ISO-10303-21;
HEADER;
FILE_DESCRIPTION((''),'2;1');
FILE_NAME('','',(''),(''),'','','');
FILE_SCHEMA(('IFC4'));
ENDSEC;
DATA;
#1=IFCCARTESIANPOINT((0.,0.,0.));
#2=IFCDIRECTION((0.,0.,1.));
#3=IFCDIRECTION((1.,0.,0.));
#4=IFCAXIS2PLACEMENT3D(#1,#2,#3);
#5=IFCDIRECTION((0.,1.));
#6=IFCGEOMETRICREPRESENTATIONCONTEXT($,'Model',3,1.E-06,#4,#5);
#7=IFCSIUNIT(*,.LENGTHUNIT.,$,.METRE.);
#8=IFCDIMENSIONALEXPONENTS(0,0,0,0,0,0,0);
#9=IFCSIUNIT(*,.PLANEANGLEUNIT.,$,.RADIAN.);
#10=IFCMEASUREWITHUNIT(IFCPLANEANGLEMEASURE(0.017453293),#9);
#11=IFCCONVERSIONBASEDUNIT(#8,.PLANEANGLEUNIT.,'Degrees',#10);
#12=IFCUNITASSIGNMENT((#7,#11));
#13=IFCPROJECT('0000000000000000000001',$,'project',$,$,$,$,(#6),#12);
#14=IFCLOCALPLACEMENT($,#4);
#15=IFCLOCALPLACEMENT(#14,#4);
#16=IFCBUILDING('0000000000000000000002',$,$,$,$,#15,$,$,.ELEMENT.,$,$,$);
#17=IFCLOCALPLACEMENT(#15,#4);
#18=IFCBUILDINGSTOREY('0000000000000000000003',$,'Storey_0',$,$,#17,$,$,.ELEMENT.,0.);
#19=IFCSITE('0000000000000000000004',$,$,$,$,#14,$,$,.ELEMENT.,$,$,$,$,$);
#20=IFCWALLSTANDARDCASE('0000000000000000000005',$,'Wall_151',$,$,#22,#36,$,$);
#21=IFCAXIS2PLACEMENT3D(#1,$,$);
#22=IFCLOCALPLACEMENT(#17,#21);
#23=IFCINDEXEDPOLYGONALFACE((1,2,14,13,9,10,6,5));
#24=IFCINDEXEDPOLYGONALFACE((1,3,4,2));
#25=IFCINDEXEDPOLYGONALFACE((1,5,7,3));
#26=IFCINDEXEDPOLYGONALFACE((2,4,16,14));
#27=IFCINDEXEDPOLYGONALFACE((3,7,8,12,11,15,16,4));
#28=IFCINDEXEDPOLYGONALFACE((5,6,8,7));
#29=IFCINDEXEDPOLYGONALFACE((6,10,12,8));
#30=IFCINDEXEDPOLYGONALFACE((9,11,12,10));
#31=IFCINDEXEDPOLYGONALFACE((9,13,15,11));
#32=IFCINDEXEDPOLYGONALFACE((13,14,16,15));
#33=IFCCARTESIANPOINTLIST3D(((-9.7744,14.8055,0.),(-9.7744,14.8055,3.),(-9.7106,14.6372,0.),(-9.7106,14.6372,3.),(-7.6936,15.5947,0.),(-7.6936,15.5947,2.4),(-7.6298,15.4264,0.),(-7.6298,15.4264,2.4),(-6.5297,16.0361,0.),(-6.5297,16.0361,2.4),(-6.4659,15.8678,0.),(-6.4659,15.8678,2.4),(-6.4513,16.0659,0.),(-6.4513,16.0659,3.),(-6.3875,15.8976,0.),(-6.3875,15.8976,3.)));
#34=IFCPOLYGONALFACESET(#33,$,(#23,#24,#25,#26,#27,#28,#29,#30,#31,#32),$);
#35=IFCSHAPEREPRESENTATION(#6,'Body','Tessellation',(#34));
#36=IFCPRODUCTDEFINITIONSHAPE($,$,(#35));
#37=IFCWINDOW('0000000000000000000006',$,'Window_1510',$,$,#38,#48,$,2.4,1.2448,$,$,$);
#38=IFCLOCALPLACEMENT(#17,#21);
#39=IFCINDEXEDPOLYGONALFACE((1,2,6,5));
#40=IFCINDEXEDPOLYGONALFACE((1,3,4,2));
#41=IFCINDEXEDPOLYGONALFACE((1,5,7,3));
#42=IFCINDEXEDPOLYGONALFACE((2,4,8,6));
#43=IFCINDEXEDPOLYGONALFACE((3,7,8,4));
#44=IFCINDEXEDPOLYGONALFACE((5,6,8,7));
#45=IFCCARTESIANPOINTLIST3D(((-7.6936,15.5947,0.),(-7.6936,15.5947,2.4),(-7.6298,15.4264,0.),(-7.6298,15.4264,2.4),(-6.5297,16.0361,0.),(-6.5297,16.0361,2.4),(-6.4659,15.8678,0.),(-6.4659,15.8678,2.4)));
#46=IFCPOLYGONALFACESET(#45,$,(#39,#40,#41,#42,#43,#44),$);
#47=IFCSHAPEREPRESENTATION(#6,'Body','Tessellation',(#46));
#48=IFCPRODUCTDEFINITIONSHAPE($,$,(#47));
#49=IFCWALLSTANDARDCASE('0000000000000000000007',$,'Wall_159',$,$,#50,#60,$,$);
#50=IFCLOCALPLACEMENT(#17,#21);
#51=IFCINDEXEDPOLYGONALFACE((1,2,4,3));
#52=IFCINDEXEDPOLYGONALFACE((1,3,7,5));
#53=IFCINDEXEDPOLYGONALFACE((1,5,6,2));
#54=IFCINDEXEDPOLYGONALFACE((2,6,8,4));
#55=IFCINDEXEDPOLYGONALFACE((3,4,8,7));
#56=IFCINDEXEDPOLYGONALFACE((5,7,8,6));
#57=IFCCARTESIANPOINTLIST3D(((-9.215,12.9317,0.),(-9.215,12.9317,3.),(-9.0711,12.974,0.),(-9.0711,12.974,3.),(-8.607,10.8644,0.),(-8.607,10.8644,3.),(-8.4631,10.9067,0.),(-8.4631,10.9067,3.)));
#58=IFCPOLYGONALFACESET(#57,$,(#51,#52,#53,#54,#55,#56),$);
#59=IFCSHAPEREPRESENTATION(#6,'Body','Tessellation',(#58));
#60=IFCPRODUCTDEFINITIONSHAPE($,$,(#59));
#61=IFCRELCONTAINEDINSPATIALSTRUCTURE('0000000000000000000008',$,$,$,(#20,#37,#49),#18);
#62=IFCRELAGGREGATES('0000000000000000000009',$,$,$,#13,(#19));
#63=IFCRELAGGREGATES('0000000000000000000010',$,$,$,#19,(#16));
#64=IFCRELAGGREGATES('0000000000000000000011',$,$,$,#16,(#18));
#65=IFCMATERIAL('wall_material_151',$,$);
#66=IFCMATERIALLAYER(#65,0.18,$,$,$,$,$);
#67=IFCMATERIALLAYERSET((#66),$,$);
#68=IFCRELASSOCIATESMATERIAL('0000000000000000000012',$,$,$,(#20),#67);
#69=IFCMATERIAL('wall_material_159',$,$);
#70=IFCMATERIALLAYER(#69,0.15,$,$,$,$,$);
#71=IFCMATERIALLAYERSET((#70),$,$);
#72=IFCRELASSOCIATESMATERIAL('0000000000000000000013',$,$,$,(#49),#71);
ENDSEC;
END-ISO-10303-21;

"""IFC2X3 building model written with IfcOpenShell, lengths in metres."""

from ifc_helpers import new_model, entity, si_unit, converted_unit, direction, frame, frame_2d, origin_with_axes, place, context, project, spatial, polyline, rectangle, outline, extrude, material, layer, layer_set, layer_usage, element, fill, save


model = new_model("IFC2X3")

# Units and contexts
model_context = context("Model", 3, precision=1e-06, world=origin_with_axes(), true_north=direction((0.0, 1.0)))
ifc_project = project(units=[si_unit("LENGTHUNIT", "METRE"), converted_unit("PLANEANGLEUNIT", "Degrees", entity("IfcPlaneAngleMeasure", 0.017453293), si_unit("PLANEANGLEUNIT", "RADIAN"), dimensions=[0, 0, 0, 0, 0, 0, 0])], contexts=[model_context])

# Site, building, storey
site_placement = place(None, origin_with_axes())
site = spatial("IfcSite", under=ifc_project, at=site_placement, CompositionType="ELEMENT")
building_placement = place(site_placement, origin_with_axes())
building = spatial("IfcBuilding", under=site, at=building_placement, CompositionType="ELEMENT")
storey_placement = place(building_placement, origin_with_axes())
storey = spatial("IfcBuildingStorey", under=building, at=storey_placement, Name="Storey_0", CompositionType="ELEMENT", Elevation=0.0)

# Wall, opening, window
ifc_material_1 = material(Name="wall_material_151")
ifc_layer_1 = layer(ifc_material_1, 0.18)
ifc_layer_set_1 = layer_set([ifc_layer_1])
ifc_layer_usage_1 = layer_usage(ifc_layer_set_1, "AXIS2", "NEGATIVE", 0.0)
wall_1_placement = place(storey_placement, frame((-9.7744, 14.8055, 0.0), z_axis=(0.0, 0.0, 1.0), x_axis=(0.935011, 0.354617, 0.0)))
wall_1 = element("IfcWallStandardCase", 1, at=wall_1_placement, inside=storey, material=ifc_layer_usage_1, Name="Wall_151", context=model_context, shape_type="SweptSolid", body=[
    extrude(outline(polyline([(0.0, 0.0), (3.5541, 0.0), (3.5541, -0.18), (0.0, -0.18), (0.0, 0.0)])), origin_with_axes(), (0.0, 0.0, 1.0), 3.0),
])
opening_1_placement = place(wall_1_placement, frame((2.2254, 0.0, 0.0), z_axis=(0.0, 0.0, 1.0), x_axis=(1.0, 0.0, 0.0)))
opening_1 = element("IfcOpeningElement", 2, at=opening_1_placement, cuts=wall_1, context=model_context, shape_type="SweptSolid", body=[
    extrude(rectangle(XDim=1.2448, YDim=2.4, at=frame_2d((1.2, -0.6224), x_axis=(0.0, 1.0))), frame((0.0, 0.01, 0.0), z_axis=(0.0, -1.0, 0.0), x_axis=(0.0, 0.0, 1.0)), (0.0, 0.0, 1.0), 0.2),
])
window_1_placement = place(storey_placement, origin_with_axes())
window_1 = element("IfcWindow", 3, at=window_1_placement, inside=storey, Name="Window_1510", OverallHeight=2.4, OverallWidth=1.2448, context=model_context, shape_type="SweptSolid", body=[
    extrude(outline(polyline([(-7.6936, 15.5947), (-6.5297, 16.0361), (-6.4659, 15.8678), (-7.6298, 15.4264), (-7.6936, 15.5947)])), origin_with_axes(), (0.0, 0.0, 1.0), 2.4),
])
fill(opening_1, window_1)

# Wall
ifc_material_2 = material(Name="wall_material_159")
ifc_layer_2 = layer(ifc_material_2, 0.15)
ifc_layer_set_2 = layer_set([ifc_layer_2])
ifc_layer_usage_2 = layer_usage(ifc_layer_set_2, "AXIS2", "NEGATIVE", 0.0)
wall_2_placement = place(storey_placement, frame((-9.0711, 12.974, 0.0), z_axis=(0.0, 0.0, 1.0), x_axis=(0.282174, -0.959363, 0.0)))
element("IfcWallStandardCase", 4, at=wall_2_placement, inside=storey, material=ifc_layer_usage_2, Name="Wall_159", context=model_context, shape_type="SweptSolid", body=[
    extrude(outline(polyline([(0.0, 0.0), (2.1549, 0.0), (2.1549, -0.15), (0.0, -0.15), (0.0, 0.0)])), origin_with_axes(), (0.0, 0.0, 1.0), 3.0),
])

save(model, "model.ifc")
